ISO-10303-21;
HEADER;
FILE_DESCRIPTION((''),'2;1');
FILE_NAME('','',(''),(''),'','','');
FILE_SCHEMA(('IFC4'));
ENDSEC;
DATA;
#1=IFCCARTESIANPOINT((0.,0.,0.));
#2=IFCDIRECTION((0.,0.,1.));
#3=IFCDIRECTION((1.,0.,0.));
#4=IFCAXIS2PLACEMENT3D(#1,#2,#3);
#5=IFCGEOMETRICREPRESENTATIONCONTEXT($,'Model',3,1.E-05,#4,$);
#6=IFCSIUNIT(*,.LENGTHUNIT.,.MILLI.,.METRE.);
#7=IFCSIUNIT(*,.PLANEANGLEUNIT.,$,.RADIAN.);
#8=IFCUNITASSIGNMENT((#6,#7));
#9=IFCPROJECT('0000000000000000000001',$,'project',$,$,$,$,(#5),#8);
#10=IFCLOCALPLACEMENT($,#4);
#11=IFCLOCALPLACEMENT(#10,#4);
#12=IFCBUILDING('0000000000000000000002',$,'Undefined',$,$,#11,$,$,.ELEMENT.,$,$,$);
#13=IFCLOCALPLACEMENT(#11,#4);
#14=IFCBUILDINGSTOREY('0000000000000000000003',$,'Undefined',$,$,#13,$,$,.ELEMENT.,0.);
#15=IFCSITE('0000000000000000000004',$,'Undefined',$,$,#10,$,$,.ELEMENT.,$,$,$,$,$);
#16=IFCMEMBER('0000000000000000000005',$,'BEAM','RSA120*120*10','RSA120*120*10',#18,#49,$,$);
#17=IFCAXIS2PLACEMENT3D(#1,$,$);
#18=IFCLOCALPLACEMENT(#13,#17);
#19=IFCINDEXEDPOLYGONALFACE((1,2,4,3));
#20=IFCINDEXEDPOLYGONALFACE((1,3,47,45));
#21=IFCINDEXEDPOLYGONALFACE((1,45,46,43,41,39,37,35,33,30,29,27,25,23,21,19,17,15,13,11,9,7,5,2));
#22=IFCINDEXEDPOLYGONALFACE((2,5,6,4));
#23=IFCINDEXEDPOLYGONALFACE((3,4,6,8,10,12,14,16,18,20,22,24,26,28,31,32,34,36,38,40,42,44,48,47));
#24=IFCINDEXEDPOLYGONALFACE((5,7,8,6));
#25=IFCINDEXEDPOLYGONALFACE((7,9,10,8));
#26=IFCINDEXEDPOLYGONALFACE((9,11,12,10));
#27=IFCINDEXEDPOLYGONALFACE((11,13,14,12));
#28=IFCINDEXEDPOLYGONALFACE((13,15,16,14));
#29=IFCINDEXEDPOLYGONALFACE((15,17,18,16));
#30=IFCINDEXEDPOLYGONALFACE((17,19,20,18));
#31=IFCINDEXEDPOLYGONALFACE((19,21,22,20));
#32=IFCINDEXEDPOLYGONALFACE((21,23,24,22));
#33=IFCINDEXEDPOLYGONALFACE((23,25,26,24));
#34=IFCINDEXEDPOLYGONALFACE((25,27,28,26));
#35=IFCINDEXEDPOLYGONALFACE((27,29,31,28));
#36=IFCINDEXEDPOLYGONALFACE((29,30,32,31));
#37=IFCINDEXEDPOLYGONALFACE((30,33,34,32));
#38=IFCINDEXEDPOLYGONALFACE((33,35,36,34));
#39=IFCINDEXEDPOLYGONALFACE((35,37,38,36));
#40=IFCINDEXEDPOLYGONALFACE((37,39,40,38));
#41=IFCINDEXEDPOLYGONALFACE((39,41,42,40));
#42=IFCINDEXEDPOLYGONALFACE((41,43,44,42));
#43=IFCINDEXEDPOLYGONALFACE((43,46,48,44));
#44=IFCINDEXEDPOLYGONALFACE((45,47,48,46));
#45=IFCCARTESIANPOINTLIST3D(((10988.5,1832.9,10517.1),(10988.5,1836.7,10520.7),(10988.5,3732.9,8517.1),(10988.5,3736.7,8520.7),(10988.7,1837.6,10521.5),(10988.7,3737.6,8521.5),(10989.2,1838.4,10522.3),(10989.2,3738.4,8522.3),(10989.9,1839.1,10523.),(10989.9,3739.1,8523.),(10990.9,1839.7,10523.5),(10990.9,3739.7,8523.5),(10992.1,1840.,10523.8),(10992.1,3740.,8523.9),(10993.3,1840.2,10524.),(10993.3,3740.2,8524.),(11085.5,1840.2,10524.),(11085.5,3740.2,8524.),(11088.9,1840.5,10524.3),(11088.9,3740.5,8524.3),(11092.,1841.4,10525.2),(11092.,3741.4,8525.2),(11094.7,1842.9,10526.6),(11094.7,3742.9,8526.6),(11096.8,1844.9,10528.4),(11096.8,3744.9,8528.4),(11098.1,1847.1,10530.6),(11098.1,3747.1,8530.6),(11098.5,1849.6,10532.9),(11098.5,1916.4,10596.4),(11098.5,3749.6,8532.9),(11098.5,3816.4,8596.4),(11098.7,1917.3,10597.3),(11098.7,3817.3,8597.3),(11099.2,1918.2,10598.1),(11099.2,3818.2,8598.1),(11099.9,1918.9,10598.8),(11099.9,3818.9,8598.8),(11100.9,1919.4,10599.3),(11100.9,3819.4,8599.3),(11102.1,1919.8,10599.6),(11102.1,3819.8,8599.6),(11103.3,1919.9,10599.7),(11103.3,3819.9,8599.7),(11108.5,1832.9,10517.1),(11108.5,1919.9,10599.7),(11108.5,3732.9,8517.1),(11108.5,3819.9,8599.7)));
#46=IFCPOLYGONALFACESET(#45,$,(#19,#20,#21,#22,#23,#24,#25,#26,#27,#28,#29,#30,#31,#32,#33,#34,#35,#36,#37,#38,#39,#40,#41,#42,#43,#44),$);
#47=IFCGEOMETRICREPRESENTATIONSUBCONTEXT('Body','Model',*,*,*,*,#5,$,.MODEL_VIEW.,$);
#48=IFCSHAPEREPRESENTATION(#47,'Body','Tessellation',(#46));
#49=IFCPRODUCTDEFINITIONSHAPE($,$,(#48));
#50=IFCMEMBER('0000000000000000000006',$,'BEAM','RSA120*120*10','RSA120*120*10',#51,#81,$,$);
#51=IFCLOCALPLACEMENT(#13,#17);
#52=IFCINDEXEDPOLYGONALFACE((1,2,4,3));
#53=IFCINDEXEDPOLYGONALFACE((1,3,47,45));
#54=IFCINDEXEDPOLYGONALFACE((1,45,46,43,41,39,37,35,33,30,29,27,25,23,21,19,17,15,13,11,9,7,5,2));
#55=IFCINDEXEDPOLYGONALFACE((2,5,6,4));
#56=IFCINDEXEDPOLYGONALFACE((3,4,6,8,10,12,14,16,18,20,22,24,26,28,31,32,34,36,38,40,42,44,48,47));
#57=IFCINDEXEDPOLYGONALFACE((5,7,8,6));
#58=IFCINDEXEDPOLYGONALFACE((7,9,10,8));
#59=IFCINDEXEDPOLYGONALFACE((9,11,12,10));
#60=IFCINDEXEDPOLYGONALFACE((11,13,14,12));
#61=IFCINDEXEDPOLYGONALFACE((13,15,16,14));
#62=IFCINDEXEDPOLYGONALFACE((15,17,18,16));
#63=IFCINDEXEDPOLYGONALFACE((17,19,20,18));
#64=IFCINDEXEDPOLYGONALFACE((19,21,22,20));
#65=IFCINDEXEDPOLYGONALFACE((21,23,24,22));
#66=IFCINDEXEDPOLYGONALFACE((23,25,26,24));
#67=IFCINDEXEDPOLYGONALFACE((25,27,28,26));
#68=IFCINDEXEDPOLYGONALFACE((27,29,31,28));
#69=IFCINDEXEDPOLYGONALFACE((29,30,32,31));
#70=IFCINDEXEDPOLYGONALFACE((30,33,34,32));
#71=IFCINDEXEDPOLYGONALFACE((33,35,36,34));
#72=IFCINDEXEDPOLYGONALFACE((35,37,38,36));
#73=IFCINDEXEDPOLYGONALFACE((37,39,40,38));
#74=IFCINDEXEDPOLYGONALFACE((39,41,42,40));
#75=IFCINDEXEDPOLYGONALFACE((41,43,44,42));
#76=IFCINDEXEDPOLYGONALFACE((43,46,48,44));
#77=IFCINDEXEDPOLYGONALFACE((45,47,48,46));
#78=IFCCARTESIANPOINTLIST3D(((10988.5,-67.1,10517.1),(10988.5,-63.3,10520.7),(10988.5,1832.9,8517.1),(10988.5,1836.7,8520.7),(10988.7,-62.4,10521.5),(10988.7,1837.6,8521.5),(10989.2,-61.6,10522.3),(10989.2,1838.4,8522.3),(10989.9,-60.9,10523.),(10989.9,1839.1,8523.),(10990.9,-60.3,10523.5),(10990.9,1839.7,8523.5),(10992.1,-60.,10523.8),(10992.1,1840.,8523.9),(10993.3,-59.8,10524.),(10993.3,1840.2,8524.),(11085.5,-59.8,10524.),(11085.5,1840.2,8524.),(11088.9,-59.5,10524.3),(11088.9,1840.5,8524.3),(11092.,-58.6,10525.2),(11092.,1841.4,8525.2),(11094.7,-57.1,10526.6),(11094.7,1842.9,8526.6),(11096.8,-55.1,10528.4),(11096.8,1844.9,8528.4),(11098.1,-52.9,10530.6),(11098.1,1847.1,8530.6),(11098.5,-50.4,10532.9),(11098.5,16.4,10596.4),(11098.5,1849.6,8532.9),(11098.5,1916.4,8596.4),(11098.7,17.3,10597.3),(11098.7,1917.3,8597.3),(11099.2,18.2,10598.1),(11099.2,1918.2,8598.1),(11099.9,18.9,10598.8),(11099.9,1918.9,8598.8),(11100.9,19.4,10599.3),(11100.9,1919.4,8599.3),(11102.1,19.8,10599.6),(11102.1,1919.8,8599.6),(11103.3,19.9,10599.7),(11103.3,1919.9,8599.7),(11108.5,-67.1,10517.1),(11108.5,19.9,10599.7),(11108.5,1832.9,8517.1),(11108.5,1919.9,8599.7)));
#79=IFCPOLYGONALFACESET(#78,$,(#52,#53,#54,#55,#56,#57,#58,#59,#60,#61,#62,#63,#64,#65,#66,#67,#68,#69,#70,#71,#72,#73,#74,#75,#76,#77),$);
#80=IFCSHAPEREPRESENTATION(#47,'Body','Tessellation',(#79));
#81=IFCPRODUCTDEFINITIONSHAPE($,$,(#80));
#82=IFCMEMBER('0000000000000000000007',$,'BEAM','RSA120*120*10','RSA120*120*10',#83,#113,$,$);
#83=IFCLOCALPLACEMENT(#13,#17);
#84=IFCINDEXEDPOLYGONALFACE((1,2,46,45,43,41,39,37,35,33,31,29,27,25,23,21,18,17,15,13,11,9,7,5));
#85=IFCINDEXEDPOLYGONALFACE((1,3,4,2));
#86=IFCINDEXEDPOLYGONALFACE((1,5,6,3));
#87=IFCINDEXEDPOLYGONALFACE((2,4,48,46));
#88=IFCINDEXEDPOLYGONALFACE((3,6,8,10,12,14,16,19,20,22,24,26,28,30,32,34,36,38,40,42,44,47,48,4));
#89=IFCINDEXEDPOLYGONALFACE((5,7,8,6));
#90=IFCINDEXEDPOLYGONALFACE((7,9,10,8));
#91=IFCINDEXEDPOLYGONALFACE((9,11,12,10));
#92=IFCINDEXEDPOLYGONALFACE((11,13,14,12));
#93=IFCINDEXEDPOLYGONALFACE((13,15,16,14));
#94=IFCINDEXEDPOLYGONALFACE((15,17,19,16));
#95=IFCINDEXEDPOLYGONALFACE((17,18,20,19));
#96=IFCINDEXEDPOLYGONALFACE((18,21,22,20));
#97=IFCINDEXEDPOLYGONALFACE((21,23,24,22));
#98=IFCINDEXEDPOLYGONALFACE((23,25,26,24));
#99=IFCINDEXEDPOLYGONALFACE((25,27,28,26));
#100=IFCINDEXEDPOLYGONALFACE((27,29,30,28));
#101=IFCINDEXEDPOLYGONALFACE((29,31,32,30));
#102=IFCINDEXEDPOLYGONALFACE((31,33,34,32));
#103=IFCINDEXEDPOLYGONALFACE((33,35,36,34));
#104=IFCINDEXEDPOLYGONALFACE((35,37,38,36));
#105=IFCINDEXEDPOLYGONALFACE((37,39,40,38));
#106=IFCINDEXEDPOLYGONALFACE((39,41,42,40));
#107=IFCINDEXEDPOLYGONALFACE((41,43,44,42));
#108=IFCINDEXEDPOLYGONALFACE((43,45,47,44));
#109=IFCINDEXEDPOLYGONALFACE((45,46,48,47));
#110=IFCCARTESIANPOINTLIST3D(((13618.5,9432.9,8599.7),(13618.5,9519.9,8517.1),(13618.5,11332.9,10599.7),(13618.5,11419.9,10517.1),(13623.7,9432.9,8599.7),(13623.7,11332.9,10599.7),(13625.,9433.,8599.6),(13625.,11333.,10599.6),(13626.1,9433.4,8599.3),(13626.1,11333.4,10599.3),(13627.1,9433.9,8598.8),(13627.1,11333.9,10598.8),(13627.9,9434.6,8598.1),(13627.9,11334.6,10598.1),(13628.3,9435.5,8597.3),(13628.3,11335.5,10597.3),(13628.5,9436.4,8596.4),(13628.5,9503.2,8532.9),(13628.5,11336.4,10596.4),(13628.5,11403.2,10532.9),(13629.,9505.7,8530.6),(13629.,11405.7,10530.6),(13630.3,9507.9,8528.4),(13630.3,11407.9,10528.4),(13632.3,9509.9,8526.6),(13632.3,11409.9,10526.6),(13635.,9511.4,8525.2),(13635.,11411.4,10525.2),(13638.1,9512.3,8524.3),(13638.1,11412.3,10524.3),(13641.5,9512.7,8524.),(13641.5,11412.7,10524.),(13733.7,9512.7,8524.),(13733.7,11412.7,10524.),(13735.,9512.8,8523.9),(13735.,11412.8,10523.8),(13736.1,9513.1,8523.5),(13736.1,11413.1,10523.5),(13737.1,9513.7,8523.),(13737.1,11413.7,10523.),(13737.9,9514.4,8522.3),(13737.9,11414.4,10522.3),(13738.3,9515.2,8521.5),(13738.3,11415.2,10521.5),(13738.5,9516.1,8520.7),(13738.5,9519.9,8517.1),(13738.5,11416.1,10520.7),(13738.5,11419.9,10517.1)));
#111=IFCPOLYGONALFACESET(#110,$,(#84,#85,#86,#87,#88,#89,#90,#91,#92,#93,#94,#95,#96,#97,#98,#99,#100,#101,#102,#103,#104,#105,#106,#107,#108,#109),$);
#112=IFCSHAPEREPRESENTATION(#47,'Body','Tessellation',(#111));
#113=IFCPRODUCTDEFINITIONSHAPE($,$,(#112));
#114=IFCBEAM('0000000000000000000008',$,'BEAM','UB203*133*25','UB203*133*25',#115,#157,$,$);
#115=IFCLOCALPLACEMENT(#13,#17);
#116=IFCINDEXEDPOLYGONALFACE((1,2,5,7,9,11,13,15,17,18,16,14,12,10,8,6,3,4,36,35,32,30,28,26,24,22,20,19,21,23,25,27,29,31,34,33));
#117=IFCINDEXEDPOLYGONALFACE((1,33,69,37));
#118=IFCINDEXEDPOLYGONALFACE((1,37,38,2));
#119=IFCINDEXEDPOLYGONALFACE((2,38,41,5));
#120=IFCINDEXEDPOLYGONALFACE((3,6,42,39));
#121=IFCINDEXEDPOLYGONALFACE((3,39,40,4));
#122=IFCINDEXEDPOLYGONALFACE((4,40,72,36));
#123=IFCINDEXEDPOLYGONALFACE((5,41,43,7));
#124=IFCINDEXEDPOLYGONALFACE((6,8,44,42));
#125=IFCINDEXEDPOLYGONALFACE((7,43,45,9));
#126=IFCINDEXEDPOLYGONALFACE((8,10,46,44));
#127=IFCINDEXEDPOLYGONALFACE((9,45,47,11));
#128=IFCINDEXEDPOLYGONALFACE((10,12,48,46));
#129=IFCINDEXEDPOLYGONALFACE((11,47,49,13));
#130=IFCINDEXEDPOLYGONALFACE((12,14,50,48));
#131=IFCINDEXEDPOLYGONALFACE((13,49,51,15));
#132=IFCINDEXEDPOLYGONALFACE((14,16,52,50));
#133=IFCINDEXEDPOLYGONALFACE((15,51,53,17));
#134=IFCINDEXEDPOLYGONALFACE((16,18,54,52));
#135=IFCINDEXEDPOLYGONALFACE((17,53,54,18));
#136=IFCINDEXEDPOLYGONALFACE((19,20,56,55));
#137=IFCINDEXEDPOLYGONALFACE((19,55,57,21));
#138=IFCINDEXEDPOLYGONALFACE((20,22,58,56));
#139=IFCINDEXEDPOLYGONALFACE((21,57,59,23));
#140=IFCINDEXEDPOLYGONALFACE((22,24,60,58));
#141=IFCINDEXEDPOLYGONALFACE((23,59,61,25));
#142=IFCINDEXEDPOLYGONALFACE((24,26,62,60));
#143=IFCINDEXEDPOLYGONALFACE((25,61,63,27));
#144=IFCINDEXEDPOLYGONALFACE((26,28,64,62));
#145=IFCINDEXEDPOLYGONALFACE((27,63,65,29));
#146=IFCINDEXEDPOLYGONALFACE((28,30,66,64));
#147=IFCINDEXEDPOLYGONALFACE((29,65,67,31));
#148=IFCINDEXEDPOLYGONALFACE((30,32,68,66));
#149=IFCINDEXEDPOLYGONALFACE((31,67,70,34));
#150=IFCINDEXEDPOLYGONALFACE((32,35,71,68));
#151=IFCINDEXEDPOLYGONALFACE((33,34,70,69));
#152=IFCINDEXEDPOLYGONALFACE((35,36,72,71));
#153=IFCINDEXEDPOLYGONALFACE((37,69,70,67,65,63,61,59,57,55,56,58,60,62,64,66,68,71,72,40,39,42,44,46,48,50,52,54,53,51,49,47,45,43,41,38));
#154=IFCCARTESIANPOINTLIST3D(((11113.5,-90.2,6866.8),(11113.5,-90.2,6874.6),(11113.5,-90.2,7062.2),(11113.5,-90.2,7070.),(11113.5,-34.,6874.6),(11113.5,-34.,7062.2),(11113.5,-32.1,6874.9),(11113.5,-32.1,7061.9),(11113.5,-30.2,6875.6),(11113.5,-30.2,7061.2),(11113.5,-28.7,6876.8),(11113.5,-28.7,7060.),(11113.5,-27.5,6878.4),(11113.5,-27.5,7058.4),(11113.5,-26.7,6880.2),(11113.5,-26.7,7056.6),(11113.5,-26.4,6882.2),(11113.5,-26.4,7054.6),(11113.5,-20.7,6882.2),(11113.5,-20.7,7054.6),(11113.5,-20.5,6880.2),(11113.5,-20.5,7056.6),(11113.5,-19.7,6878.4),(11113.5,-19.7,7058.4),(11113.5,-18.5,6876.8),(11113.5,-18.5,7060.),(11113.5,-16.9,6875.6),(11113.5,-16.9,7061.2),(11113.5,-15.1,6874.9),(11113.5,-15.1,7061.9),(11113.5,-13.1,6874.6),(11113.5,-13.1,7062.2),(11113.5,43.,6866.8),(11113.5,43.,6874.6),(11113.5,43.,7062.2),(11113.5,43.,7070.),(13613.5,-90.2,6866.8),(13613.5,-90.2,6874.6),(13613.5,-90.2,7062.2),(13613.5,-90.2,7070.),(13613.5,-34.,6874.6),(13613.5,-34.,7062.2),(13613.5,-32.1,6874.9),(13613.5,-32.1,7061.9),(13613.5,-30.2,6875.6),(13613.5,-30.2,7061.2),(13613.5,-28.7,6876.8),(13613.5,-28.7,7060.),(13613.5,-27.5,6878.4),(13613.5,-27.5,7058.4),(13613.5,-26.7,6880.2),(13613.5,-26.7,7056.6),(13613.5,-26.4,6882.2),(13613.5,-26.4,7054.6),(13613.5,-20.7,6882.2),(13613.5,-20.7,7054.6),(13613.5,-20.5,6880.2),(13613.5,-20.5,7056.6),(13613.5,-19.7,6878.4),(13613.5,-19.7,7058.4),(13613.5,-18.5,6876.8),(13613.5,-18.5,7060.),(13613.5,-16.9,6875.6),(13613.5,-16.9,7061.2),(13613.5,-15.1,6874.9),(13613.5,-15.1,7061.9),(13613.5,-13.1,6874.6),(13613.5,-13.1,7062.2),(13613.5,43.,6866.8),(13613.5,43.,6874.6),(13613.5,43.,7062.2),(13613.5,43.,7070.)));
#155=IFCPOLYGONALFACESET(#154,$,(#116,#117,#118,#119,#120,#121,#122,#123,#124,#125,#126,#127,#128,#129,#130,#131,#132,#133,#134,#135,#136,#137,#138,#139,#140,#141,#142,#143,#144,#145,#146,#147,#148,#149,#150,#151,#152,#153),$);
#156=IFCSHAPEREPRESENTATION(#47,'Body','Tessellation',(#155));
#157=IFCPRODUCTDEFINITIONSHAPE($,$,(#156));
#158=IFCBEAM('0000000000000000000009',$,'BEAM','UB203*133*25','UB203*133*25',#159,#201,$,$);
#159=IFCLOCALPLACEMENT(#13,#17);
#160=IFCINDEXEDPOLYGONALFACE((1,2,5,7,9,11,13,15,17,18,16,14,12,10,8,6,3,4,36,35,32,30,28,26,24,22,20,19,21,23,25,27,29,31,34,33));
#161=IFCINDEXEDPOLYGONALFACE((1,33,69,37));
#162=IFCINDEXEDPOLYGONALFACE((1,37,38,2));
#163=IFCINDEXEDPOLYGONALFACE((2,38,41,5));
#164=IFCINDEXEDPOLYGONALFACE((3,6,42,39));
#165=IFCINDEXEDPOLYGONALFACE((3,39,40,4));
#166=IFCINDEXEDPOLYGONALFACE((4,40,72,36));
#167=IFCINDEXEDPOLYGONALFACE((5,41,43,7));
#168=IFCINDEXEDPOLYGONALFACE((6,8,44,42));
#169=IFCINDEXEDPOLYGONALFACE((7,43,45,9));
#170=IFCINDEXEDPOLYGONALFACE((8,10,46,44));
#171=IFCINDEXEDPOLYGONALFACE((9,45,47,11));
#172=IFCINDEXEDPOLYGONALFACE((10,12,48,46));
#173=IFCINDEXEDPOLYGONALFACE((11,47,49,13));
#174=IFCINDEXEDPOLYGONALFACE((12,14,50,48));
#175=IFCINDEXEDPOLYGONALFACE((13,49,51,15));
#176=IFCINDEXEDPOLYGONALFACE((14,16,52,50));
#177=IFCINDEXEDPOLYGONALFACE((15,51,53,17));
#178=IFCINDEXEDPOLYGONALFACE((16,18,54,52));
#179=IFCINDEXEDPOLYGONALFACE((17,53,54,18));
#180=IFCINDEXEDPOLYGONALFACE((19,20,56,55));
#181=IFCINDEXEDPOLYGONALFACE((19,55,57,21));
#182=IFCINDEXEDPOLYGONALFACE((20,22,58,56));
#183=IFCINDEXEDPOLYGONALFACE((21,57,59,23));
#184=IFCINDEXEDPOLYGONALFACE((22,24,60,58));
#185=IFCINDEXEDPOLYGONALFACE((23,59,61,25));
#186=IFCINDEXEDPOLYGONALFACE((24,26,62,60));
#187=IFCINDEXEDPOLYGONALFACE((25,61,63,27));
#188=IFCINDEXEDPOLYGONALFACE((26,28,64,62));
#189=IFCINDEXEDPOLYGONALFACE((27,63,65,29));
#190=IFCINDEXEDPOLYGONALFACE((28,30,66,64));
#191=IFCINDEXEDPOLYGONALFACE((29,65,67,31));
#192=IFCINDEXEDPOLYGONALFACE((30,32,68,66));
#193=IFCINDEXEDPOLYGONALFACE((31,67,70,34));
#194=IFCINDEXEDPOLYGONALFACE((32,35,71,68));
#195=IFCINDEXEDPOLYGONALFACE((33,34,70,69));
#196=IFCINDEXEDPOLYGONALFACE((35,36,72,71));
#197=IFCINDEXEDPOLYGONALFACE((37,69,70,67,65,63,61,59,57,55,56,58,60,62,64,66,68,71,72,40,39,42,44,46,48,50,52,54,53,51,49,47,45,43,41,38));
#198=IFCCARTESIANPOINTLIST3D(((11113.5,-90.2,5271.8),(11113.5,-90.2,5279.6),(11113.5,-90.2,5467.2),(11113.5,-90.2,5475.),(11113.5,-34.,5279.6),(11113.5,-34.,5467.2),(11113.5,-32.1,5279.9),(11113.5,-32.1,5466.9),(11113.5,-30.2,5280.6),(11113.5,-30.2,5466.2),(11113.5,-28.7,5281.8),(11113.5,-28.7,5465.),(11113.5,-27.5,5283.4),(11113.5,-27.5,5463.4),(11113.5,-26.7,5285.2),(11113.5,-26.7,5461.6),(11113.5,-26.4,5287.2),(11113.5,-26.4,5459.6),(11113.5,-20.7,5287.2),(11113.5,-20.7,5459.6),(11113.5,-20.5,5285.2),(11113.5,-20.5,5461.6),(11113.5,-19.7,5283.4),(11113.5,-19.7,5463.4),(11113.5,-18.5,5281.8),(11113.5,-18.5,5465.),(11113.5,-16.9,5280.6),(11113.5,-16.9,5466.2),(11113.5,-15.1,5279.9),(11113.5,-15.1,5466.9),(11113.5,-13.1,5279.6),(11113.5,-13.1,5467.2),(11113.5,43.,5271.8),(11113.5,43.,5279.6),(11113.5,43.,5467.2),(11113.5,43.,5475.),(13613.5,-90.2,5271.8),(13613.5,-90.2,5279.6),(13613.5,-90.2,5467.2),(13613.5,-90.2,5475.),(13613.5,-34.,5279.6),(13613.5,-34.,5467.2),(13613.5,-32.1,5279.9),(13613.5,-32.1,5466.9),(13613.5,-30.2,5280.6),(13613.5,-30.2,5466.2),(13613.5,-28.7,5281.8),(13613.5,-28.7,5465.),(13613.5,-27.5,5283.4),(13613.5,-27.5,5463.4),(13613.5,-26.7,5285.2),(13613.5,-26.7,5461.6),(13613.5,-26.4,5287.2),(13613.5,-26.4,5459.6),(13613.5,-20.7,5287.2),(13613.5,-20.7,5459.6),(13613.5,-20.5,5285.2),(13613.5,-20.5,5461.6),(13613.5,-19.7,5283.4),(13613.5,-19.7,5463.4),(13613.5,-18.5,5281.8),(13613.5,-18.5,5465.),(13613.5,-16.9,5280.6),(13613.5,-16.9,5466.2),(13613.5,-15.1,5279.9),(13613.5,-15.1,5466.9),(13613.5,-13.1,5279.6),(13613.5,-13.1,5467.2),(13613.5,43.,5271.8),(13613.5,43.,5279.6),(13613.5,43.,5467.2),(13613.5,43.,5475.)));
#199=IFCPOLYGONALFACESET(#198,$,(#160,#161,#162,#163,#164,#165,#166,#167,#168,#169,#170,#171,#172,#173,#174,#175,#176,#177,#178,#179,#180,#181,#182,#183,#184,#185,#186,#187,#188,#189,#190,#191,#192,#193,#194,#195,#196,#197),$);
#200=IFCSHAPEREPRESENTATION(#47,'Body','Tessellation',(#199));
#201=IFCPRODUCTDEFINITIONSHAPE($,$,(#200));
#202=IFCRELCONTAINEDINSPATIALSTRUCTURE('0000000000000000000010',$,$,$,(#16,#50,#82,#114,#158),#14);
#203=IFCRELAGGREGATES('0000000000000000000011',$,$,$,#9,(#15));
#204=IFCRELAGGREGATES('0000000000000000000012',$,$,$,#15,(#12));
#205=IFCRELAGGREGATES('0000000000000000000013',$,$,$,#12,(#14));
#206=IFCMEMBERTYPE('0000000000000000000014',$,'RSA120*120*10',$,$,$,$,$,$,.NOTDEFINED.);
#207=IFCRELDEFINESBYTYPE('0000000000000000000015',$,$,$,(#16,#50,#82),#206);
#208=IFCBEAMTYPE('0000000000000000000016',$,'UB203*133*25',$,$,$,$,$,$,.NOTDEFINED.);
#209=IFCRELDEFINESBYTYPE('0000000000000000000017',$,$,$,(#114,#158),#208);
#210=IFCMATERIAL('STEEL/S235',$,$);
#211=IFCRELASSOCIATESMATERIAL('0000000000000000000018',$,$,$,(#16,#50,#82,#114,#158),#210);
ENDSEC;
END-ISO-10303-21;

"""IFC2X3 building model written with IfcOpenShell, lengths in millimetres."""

from ifc_helpers import new_model, si_unit, frame, origin_with_axes, origin_2d_with_axis, place, context, subcontext, project, spatial, i_section, l_section, extrude, material, type_object, element, save


model = new_model("IFC2X3")

# Units and contexts
model_context = context("Model", 3, precision=1e-05, world=origin_with_axes())
body_context = subcontext(model_context, "Body", "Model", "MODEL_VIEW")
ifc_project = project(units=[si_unit("LENGTHUNIT", "METRE", prefix="MILLI"), si_unit("PLANEANGLEUNIT", "RADIAN")], contexts=[model_context])

# Site, building, storey
site_placement = place(None, origin_with_axes())
site = spatial("IfcSite", under=ifc_project, at=site_placement, Name="Undefined", CompositionType="ELEMENT")
building_placement = place(site_placement, origin_with_axes())
building = spatial("IfcBuilding", under=site, at=building_placement, Name="Undefined", CompositionType="ELEMENT")
storey_placement = place(building_placement, origin_with_axes())
storey = spatial("IfcBuildingStorey", under=building, at=storey_placement, Name="Undefined", CompositionType="ELEMENT", Elevation=0.0)

# Shared definitions
ifc_material = material(Name="STEEL/S235")

# Members
member_type_1 = type_object("IfcMemberType", Name="RSA120*120*10", PredefinedType="NOTDEFINED")
for number, where, z_axis, x_axis, name in (
    (1, (11048.5, 3776.4, 8558.4), (0.0, 0.724999, 0.688749), (0.0, -0.688749, 0.724999), "BEAM"),
    (2, (11048.5, 1876.4, 8558.4), (0.0, 0.724999, 0.688749), (0.0, -0.688749, 0.724999), "BEAM"),
    (3, (13678.5, 9476.4, 8558.4), (0.0, -0.724999, 0.688749), (0.0, 0.688749, 0.724999), "BEAM"),
):
    element("IfcMember", number, at=place(storey_placement, frame(where, z_axis=z_axis, x_axis=x_axis)), inside=storey, type_object=member_type_1, material=ifc_material, Name=name, Description="RSA120*120*10", ObjectType="RSA120*120*10", context=body_context, shape_type="SweptSolid", body=[
        extrude(l_section(Depth=120.0, Width=120.0, Thickness=10.0, FilletRadius=13.0, EdgeRadius=4.8, at=origin_2d_with_axis()), frame((2758.6, 0.0, 0.0), z_axis=(-1.0, 0.0, 0.0), x_axis=(0.0, -1.0, 0.0)), (0.0, 0.0, 1.0), 2758.6),
    ])

# Beams
beam_type_1 = type_object("IfcBeamType", Name="UB203*133*25", PredefinedType="NOTDEFINED")
for number, where, z_axis, x_axis, name in (
    (4, (11113.5, -23.6, 6968.4), (0.0, 0.0, 1.0), (1.0, 0.0, 0.0), "BEAM"),
    (5, (11113.5, -23.6, 5373.4), (0.0, 0.0, 1.0), (1.0, 0.0, 0.0), "BEAM"),
):
    element("IfcBeam", number, at=place(storey_placement, frame(where, z_axis=z_axis, x_axis=x_axis)), inside=storey, type_object=beam_type_1, material=ifc_material, Name=name, Description="UB203*133*25", ObjectType="UB203*133*25", context=body_context, shape_type="SweptSolid", body=[
        extrude(i_section(OverallWidth=133.2, OverallDepth=203.2, WebThickness=5.7, FlangeThickness=7.8, FilletRadius=7.6, at=origin_2d_with_axis()), frame((2500.0, 0.0, 0.0), z_axis=(-1.0, 0.0, 0.0), x_axis=(0.0, -1.0, 0.0)), (0.0, 0.0, 1.0), 2500.0),
    ])

save(model, "model.ifc")
